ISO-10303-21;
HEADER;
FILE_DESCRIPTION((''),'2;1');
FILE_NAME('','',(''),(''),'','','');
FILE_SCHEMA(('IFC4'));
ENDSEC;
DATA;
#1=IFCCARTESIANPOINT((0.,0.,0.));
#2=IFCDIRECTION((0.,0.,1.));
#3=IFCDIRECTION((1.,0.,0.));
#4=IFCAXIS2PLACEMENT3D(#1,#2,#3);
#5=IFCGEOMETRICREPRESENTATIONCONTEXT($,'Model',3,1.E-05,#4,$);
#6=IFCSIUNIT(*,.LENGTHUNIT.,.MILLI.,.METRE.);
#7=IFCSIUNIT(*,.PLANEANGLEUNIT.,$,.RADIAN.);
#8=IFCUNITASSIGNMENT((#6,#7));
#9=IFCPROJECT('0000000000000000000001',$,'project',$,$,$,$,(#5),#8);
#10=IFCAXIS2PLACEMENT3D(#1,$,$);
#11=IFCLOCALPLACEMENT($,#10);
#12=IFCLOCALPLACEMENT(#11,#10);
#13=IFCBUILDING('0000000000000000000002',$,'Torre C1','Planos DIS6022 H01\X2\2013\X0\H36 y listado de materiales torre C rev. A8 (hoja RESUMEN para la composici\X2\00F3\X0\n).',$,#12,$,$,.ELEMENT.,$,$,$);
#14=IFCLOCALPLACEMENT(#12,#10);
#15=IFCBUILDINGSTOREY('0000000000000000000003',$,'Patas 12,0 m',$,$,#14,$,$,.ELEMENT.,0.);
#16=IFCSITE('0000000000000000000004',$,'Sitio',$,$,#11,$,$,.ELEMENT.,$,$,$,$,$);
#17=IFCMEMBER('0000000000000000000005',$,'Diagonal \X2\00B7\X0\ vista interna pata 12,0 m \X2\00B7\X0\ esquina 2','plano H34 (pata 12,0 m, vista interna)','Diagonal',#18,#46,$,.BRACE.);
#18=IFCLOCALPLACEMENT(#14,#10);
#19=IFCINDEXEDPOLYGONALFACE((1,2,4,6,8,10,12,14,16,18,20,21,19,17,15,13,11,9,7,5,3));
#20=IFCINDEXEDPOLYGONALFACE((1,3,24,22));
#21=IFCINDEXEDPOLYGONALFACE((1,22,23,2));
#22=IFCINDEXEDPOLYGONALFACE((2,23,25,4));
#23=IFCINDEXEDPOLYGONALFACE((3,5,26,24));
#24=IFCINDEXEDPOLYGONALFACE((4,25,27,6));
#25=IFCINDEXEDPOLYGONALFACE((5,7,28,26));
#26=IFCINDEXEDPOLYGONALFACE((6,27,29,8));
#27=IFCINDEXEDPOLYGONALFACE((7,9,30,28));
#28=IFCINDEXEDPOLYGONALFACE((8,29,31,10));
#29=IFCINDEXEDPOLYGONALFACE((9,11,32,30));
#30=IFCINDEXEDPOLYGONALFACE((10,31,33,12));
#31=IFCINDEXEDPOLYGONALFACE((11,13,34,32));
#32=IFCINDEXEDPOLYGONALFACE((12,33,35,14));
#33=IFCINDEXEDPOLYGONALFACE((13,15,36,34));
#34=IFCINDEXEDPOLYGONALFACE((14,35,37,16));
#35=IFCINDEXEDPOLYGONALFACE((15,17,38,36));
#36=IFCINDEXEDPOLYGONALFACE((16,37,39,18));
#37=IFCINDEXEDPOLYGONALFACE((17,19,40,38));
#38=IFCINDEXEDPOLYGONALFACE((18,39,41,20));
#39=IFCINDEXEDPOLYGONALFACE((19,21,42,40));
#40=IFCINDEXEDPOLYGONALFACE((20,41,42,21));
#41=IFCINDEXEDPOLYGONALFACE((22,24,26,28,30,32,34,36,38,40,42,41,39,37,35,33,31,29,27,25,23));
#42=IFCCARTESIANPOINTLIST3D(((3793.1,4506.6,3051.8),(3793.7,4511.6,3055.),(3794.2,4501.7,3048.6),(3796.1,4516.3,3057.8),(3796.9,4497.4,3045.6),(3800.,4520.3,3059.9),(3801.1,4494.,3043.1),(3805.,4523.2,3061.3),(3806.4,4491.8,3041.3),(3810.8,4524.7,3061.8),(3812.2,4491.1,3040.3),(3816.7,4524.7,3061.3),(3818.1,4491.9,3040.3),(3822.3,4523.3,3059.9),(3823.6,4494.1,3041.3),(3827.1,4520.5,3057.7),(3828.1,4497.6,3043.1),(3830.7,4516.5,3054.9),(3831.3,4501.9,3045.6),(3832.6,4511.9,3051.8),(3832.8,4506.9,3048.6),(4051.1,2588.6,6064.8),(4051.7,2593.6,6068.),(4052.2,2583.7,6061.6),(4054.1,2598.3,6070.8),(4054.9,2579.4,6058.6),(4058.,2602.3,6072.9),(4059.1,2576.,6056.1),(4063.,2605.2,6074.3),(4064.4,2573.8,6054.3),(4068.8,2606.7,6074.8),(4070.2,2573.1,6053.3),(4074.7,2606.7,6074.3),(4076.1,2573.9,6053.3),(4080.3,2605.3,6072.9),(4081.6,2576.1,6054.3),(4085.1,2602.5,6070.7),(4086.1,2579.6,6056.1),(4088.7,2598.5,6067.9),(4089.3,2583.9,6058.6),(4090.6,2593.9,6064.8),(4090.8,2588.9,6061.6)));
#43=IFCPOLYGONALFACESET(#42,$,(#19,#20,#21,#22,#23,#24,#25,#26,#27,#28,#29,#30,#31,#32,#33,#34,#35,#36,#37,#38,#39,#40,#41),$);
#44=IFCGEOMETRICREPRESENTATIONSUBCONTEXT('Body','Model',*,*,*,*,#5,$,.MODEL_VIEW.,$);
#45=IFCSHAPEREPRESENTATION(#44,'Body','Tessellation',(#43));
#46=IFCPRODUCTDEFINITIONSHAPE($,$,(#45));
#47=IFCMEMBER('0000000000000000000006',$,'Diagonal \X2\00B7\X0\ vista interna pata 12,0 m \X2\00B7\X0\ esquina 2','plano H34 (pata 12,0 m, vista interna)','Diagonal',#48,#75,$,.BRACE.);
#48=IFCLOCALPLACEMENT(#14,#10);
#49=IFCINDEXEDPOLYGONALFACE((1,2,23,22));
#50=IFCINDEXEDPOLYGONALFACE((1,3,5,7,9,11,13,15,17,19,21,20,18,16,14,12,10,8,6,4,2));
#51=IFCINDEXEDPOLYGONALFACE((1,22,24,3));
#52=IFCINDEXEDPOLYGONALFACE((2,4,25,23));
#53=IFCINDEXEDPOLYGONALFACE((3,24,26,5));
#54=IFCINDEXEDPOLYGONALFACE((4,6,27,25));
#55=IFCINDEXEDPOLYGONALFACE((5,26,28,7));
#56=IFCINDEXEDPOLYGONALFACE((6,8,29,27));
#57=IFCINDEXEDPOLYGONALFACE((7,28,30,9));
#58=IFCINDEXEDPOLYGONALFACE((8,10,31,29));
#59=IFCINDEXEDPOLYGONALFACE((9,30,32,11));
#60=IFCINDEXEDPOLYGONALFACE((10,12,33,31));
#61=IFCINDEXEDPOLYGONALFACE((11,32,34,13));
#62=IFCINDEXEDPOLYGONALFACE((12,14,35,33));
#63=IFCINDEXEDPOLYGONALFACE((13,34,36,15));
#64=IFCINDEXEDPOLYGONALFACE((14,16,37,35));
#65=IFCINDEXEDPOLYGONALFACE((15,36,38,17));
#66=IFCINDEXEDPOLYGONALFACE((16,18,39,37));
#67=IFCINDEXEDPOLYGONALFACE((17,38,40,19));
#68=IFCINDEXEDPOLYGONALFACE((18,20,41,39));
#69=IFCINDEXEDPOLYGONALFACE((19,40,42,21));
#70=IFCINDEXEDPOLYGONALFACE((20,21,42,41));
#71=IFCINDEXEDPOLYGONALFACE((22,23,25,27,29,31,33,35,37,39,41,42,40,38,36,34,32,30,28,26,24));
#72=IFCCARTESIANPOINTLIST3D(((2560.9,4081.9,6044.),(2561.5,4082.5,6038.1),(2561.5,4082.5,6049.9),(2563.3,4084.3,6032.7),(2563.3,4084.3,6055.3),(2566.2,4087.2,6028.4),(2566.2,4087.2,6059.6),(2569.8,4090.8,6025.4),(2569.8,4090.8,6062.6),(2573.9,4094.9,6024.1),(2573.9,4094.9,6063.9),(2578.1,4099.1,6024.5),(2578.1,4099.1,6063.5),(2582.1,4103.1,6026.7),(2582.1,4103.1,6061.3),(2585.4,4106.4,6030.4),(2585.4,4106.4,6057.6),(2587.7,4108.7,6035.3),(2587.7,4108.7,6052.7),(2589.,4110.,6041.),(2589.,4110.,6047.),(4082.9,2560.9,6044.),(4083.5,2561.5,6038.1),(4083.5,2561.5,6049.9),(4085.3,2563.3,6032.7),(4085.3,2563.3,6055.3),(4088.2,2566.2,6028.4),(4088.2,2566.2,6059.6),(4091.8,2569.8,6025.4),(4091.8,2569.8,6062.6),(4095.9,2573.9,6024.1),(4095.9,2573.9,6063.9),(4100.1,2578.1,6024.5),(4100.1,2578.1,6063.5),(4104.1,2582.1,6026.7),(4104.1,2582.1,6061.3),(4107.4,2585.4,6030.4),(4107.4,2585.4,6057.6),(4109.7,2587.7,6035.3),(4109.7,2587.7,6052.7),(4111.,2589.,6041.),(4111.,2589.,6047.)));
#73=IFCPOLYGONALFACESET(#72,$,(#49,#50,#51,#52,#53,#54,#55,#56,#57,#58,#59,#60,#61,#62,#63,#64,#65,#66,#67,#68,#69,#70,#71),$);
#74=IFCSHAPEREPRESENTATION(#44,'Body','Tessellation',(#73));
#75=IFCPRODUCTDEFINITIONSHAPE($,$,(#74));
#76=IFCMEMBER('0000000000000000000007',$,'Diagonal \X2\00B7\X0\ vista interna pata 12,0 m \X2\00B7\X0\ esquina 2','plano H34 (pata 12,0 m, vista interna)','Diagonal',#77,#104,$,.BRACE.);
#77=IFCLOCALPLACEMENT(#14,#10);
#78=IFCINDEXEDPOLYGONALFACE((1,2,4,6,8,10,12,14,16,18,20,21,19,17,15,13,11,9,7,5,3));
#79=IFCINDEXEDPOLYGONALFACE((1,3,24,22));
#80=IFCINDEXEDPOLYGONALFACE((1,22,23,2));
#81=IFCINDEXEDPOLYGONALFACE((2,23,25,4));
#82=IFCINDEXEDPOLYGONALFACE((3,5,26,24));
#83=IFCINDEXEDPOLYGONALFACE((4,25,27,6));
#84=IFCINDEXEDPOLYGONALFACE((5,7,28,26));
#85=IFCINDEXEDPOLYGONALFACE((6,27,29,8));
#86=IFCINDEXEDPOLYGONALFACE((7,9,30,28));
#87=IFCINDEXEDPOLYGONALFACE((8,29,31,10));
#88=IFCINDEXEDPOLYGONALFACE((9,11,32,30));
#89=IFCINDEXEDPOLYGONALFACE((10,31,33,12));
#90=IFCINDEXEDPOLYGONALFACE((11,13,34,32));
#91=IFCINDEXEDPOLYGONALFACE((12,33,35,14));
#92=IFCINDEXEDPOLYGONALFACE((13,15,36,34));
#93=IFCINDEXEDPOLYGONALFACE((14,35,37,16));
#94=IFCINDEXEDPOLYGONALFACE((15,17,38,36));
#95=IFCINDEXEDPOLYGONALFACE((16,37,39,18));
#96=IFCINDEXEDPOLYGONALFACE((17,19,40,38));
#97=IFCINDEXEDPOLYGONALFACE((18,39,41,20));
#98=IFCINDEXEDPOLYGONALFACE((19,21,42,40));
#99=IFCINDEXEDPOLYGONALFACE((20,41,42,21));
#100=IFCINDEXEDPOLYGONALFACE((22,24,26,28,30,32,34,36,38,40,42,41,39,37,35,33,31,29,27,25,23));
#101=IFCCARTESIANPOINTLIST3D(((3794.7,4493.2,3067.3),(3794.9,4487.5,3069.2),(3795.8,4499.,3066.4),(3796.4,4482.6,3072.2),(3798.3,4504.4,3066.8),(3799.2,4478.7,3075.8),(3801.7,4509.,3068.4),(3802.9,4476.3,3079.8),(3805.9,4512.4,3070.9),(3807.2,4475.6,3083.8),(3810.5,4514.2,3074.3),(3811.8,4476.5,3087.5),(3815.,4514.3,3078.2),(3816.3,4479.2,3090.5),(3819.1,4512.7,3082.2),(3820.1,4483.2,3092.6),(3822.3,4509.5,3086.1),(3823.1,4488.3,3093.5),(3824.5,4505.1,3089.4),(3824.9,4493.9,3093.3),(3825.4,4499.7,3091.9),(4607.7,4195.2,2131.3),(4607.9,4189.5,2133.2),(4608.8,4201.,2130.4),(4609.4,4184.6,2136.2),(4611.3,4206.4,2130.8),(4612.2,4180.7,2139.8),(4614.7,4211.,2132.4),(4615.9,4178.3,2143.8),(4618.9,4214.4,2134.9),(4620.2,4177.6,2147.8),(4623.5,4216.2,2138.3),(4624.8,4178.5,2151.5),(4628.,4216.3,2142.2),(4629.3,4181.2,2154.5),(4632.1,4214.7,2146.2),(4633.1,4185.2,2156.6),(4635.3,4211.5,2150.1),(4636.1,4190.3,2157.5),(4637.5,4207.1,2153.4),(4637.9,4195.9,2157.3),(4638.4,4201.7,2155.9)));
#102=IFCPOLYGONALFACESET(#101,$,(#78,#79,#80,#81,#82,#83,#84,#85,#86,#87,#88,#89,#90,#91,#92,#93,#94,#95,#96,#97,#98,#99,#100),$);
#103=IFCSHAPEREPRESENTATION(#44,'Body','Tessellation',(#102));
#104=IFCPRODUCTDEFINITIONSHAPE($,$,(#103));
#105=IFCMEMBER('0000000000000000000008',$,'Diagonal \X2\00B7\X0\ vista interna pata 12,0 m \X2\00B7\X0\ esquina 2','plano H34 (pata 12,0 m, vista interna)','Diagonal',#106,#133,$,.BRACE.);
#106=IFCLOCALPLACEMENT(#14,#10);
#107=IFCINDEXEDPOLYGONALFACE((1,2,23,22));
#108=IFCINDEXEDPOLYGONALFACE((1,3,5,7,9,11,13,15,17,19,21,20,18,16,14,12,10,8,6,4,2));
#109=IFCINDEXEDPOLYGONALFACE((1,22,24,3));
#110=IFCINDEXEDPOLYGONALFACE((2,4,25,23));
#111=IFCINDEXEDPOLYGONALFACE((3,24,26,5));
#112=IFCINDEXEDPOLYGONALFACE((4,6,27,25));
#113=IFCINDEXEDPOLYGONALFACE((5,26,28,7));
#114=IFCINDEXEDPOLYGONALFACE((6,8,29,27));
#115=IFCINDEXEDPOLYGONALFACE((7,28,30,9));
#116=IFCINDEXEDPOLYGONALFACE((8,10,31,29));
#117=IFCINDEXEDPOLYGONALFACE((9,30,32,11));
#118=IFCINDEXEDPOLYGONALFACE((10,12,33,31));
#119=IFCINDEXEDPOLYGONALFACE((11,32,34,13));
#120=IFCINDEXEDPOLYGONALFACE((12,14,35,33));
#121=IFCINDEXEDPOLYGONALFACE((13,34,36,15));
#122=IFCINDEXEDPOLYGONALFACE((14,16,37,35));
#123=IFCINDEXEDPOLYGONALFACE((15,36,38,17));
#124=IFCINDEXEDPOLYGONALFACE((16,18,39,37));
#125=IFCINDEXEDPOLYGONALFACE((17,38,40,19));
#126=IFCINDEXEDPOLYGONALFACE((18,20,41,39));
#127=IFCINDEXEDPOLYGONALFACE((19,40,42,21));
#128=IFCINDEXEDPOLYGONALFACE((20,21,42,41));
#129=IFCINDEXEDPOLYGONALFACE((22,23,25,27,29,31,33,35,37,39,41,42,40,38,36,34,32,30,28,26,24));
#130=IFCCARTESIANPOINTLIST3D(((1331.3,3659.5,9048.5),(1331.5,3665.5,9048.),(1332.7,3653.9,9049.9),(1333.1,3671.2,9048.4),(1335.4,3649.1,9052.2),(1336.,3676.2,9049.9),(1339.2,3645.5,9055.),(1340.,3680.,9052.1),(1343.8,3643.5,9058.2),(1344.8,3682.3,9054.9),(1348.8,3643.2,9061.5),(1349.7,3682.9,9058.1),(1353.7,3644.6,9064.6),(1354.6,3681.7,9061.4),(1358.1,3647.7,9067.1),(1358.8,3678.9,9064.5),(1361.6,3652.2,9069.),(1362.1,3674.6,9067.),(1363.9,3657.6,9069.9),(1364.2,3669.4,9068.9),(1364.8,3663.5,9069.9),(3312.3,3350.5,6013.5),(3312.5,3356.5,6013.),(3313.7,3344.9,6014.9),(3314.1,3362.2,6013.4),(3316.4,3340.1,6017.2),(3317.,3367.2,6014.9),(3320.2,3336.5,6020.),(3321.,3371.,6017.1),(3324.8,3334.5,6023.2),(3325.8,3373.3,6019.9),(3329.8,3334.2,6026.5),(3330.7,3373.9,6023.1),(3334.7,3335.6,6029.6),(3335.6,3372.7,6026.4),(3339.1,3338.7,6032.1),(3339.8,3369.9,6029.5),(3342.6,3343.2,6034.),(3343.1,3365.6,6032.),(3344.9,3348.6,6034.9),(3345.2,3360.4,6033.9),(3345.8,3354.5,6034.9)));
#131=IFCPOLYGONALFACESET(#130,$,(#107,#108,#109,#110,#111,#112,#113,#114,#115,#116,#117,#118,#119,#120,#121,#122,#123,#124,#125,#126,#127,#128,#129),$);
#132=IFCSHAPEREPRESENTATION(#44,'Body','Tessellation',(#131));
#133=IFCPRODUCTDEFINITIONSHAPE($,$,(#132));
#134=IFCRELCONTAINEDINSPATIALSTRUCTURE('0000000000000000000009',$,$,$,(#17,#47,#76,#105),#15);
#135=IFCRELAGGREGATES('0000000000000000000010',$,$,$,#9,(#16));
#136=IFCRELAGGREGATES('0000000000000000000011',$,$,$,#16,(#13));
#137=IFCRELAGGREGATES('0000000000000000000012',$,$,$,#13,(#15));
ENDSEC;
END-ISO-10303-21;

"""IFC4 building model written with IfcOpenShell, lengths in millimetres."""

from ifc_helpers import new_model, si_unit, frame, origin, origin_with_axes, place, context, subcontext, project, spatial, circle, extrude, element, save


model = new_model("IFC4")

# Units and contexts
model_context = context("Model", 3, precision=1e-05, world=origin_with_axes())
body_context = subcontext(model_context, "Body", "Model", "MODEL_VIEW")
ifc_project = project(units=[si_unit("LENGTHUNIT", "METRE", prefix="MILLI"), si_unit("PLANEANGLEUNIT", "RADIAN")], contexts=[model_context])

# Site, building, storey
site_placement = place(None, origin())
site = spatial("IfcSite", under=ifc_project, at=site_placement, Name="Sitio", CompositionType="ELEMENT")
building_placement = place(site_placement, origin())
building = spatial("IfcBuilding", under=site, at=building_placement, Name="Torre C1", Description="Planos DIS6022 H01–H36 y listado de materiales torre C rev. A8 (hoja RESUMEN para la composición).", CompositionType="ELEMENT")
storey_placement = place(building_placement, origin())
storey = spatial("IfcBuildingStorey", under=building, at=storey_placement, Name="Patas 12,0 m", CompositionType="ELEMENT", Elevation=0.0)

# Members
member_1_placement = place(storey_placement, frame((4071.0, 2590.0, 6064.0), z_axis=(-0.072047, 0.535607, -0.841388), x_axis=(-0.803377, -0.531099, -0.269292)))
element("IfcMember", 1, at=member_1_placement, inside=storey, Name="Diagonal · vista interna pata 12,0 m · esquina 2", Description="plano H34 (pata 12,0 m, vista interna)", ObjectType="Diagonal", PredefinedType="BRACE", context=body_context, shape_type="SweptSolid", body=[
    extrude(circle(Radius=20.0), None, (0.0, 0.0, 1.0), 3581.0),
])
member_2_placement = place(storey_placement, frame((4097.0, 2575.0, 6044.0), z_axis=(-0.707339, 0.706874, 0.0), x_axis=(-0.706874, -0.707339, 0.0)))
element("IfcMember", 2, at=member_2_placement, inside=storey, Name="Diagonal · vista interna pata 12,0 m · esquina 2", Description="plano H34 (pata 12,0 m, vista interna)", ObjectType="Diagonal", PredefinedType="BRACE", context=body_context, shape_type="SweptSolid", body=[
    extrude(circle(Radius=20.0), None, (0.0, 0.0, 1.0), 2151.7),
])
member_3_placement = place(storey_placement, frame((4623.0, 4197.0, 2144.0), z_axis=(-0.637599, 0.233708, 0.734063), x_axis=(-0.541261, -0.813953, -0.210991)))
element("IfcMember", 3, at=member_3_placement, inside=storey, Name="Diagonal · vista interna pata 12,0 m · esquina 2", Description="plano H34 (pata 12,0 m, vista interna)", ObjectType="Diagonal", PredefinedType="BRACE", context=body_context, shape_type="SweptSolid", body=[
    extrude(circle(Radius=20.0), None, (0.0, 0.0, 1.0), 1275.1),
])
member_4_placement = place(storey_placement, frame((3329.0, 3354.0, 6024.0), z_axis=(-0.544612, 0.08495, 0.834375), x_axis=(-0.440568, -0.875515, -0.198429)))
element("IfcMember", 4, at=member_4_placement, inside=storey, Name="Diagonal · vista interna pata 12,0 m · esquina 2", Description="plano H34 (pata 12,0 m, vista interna)", ObjectType="Diagonal", PredefinedType="BRACE", context=body_context, shape_type="SweptSolid", body=[
    extrude(circle(Radius=20.0), None, (0.0, 0.0, 1.0), 3637.5),
])

save(model, "model.ifc")
